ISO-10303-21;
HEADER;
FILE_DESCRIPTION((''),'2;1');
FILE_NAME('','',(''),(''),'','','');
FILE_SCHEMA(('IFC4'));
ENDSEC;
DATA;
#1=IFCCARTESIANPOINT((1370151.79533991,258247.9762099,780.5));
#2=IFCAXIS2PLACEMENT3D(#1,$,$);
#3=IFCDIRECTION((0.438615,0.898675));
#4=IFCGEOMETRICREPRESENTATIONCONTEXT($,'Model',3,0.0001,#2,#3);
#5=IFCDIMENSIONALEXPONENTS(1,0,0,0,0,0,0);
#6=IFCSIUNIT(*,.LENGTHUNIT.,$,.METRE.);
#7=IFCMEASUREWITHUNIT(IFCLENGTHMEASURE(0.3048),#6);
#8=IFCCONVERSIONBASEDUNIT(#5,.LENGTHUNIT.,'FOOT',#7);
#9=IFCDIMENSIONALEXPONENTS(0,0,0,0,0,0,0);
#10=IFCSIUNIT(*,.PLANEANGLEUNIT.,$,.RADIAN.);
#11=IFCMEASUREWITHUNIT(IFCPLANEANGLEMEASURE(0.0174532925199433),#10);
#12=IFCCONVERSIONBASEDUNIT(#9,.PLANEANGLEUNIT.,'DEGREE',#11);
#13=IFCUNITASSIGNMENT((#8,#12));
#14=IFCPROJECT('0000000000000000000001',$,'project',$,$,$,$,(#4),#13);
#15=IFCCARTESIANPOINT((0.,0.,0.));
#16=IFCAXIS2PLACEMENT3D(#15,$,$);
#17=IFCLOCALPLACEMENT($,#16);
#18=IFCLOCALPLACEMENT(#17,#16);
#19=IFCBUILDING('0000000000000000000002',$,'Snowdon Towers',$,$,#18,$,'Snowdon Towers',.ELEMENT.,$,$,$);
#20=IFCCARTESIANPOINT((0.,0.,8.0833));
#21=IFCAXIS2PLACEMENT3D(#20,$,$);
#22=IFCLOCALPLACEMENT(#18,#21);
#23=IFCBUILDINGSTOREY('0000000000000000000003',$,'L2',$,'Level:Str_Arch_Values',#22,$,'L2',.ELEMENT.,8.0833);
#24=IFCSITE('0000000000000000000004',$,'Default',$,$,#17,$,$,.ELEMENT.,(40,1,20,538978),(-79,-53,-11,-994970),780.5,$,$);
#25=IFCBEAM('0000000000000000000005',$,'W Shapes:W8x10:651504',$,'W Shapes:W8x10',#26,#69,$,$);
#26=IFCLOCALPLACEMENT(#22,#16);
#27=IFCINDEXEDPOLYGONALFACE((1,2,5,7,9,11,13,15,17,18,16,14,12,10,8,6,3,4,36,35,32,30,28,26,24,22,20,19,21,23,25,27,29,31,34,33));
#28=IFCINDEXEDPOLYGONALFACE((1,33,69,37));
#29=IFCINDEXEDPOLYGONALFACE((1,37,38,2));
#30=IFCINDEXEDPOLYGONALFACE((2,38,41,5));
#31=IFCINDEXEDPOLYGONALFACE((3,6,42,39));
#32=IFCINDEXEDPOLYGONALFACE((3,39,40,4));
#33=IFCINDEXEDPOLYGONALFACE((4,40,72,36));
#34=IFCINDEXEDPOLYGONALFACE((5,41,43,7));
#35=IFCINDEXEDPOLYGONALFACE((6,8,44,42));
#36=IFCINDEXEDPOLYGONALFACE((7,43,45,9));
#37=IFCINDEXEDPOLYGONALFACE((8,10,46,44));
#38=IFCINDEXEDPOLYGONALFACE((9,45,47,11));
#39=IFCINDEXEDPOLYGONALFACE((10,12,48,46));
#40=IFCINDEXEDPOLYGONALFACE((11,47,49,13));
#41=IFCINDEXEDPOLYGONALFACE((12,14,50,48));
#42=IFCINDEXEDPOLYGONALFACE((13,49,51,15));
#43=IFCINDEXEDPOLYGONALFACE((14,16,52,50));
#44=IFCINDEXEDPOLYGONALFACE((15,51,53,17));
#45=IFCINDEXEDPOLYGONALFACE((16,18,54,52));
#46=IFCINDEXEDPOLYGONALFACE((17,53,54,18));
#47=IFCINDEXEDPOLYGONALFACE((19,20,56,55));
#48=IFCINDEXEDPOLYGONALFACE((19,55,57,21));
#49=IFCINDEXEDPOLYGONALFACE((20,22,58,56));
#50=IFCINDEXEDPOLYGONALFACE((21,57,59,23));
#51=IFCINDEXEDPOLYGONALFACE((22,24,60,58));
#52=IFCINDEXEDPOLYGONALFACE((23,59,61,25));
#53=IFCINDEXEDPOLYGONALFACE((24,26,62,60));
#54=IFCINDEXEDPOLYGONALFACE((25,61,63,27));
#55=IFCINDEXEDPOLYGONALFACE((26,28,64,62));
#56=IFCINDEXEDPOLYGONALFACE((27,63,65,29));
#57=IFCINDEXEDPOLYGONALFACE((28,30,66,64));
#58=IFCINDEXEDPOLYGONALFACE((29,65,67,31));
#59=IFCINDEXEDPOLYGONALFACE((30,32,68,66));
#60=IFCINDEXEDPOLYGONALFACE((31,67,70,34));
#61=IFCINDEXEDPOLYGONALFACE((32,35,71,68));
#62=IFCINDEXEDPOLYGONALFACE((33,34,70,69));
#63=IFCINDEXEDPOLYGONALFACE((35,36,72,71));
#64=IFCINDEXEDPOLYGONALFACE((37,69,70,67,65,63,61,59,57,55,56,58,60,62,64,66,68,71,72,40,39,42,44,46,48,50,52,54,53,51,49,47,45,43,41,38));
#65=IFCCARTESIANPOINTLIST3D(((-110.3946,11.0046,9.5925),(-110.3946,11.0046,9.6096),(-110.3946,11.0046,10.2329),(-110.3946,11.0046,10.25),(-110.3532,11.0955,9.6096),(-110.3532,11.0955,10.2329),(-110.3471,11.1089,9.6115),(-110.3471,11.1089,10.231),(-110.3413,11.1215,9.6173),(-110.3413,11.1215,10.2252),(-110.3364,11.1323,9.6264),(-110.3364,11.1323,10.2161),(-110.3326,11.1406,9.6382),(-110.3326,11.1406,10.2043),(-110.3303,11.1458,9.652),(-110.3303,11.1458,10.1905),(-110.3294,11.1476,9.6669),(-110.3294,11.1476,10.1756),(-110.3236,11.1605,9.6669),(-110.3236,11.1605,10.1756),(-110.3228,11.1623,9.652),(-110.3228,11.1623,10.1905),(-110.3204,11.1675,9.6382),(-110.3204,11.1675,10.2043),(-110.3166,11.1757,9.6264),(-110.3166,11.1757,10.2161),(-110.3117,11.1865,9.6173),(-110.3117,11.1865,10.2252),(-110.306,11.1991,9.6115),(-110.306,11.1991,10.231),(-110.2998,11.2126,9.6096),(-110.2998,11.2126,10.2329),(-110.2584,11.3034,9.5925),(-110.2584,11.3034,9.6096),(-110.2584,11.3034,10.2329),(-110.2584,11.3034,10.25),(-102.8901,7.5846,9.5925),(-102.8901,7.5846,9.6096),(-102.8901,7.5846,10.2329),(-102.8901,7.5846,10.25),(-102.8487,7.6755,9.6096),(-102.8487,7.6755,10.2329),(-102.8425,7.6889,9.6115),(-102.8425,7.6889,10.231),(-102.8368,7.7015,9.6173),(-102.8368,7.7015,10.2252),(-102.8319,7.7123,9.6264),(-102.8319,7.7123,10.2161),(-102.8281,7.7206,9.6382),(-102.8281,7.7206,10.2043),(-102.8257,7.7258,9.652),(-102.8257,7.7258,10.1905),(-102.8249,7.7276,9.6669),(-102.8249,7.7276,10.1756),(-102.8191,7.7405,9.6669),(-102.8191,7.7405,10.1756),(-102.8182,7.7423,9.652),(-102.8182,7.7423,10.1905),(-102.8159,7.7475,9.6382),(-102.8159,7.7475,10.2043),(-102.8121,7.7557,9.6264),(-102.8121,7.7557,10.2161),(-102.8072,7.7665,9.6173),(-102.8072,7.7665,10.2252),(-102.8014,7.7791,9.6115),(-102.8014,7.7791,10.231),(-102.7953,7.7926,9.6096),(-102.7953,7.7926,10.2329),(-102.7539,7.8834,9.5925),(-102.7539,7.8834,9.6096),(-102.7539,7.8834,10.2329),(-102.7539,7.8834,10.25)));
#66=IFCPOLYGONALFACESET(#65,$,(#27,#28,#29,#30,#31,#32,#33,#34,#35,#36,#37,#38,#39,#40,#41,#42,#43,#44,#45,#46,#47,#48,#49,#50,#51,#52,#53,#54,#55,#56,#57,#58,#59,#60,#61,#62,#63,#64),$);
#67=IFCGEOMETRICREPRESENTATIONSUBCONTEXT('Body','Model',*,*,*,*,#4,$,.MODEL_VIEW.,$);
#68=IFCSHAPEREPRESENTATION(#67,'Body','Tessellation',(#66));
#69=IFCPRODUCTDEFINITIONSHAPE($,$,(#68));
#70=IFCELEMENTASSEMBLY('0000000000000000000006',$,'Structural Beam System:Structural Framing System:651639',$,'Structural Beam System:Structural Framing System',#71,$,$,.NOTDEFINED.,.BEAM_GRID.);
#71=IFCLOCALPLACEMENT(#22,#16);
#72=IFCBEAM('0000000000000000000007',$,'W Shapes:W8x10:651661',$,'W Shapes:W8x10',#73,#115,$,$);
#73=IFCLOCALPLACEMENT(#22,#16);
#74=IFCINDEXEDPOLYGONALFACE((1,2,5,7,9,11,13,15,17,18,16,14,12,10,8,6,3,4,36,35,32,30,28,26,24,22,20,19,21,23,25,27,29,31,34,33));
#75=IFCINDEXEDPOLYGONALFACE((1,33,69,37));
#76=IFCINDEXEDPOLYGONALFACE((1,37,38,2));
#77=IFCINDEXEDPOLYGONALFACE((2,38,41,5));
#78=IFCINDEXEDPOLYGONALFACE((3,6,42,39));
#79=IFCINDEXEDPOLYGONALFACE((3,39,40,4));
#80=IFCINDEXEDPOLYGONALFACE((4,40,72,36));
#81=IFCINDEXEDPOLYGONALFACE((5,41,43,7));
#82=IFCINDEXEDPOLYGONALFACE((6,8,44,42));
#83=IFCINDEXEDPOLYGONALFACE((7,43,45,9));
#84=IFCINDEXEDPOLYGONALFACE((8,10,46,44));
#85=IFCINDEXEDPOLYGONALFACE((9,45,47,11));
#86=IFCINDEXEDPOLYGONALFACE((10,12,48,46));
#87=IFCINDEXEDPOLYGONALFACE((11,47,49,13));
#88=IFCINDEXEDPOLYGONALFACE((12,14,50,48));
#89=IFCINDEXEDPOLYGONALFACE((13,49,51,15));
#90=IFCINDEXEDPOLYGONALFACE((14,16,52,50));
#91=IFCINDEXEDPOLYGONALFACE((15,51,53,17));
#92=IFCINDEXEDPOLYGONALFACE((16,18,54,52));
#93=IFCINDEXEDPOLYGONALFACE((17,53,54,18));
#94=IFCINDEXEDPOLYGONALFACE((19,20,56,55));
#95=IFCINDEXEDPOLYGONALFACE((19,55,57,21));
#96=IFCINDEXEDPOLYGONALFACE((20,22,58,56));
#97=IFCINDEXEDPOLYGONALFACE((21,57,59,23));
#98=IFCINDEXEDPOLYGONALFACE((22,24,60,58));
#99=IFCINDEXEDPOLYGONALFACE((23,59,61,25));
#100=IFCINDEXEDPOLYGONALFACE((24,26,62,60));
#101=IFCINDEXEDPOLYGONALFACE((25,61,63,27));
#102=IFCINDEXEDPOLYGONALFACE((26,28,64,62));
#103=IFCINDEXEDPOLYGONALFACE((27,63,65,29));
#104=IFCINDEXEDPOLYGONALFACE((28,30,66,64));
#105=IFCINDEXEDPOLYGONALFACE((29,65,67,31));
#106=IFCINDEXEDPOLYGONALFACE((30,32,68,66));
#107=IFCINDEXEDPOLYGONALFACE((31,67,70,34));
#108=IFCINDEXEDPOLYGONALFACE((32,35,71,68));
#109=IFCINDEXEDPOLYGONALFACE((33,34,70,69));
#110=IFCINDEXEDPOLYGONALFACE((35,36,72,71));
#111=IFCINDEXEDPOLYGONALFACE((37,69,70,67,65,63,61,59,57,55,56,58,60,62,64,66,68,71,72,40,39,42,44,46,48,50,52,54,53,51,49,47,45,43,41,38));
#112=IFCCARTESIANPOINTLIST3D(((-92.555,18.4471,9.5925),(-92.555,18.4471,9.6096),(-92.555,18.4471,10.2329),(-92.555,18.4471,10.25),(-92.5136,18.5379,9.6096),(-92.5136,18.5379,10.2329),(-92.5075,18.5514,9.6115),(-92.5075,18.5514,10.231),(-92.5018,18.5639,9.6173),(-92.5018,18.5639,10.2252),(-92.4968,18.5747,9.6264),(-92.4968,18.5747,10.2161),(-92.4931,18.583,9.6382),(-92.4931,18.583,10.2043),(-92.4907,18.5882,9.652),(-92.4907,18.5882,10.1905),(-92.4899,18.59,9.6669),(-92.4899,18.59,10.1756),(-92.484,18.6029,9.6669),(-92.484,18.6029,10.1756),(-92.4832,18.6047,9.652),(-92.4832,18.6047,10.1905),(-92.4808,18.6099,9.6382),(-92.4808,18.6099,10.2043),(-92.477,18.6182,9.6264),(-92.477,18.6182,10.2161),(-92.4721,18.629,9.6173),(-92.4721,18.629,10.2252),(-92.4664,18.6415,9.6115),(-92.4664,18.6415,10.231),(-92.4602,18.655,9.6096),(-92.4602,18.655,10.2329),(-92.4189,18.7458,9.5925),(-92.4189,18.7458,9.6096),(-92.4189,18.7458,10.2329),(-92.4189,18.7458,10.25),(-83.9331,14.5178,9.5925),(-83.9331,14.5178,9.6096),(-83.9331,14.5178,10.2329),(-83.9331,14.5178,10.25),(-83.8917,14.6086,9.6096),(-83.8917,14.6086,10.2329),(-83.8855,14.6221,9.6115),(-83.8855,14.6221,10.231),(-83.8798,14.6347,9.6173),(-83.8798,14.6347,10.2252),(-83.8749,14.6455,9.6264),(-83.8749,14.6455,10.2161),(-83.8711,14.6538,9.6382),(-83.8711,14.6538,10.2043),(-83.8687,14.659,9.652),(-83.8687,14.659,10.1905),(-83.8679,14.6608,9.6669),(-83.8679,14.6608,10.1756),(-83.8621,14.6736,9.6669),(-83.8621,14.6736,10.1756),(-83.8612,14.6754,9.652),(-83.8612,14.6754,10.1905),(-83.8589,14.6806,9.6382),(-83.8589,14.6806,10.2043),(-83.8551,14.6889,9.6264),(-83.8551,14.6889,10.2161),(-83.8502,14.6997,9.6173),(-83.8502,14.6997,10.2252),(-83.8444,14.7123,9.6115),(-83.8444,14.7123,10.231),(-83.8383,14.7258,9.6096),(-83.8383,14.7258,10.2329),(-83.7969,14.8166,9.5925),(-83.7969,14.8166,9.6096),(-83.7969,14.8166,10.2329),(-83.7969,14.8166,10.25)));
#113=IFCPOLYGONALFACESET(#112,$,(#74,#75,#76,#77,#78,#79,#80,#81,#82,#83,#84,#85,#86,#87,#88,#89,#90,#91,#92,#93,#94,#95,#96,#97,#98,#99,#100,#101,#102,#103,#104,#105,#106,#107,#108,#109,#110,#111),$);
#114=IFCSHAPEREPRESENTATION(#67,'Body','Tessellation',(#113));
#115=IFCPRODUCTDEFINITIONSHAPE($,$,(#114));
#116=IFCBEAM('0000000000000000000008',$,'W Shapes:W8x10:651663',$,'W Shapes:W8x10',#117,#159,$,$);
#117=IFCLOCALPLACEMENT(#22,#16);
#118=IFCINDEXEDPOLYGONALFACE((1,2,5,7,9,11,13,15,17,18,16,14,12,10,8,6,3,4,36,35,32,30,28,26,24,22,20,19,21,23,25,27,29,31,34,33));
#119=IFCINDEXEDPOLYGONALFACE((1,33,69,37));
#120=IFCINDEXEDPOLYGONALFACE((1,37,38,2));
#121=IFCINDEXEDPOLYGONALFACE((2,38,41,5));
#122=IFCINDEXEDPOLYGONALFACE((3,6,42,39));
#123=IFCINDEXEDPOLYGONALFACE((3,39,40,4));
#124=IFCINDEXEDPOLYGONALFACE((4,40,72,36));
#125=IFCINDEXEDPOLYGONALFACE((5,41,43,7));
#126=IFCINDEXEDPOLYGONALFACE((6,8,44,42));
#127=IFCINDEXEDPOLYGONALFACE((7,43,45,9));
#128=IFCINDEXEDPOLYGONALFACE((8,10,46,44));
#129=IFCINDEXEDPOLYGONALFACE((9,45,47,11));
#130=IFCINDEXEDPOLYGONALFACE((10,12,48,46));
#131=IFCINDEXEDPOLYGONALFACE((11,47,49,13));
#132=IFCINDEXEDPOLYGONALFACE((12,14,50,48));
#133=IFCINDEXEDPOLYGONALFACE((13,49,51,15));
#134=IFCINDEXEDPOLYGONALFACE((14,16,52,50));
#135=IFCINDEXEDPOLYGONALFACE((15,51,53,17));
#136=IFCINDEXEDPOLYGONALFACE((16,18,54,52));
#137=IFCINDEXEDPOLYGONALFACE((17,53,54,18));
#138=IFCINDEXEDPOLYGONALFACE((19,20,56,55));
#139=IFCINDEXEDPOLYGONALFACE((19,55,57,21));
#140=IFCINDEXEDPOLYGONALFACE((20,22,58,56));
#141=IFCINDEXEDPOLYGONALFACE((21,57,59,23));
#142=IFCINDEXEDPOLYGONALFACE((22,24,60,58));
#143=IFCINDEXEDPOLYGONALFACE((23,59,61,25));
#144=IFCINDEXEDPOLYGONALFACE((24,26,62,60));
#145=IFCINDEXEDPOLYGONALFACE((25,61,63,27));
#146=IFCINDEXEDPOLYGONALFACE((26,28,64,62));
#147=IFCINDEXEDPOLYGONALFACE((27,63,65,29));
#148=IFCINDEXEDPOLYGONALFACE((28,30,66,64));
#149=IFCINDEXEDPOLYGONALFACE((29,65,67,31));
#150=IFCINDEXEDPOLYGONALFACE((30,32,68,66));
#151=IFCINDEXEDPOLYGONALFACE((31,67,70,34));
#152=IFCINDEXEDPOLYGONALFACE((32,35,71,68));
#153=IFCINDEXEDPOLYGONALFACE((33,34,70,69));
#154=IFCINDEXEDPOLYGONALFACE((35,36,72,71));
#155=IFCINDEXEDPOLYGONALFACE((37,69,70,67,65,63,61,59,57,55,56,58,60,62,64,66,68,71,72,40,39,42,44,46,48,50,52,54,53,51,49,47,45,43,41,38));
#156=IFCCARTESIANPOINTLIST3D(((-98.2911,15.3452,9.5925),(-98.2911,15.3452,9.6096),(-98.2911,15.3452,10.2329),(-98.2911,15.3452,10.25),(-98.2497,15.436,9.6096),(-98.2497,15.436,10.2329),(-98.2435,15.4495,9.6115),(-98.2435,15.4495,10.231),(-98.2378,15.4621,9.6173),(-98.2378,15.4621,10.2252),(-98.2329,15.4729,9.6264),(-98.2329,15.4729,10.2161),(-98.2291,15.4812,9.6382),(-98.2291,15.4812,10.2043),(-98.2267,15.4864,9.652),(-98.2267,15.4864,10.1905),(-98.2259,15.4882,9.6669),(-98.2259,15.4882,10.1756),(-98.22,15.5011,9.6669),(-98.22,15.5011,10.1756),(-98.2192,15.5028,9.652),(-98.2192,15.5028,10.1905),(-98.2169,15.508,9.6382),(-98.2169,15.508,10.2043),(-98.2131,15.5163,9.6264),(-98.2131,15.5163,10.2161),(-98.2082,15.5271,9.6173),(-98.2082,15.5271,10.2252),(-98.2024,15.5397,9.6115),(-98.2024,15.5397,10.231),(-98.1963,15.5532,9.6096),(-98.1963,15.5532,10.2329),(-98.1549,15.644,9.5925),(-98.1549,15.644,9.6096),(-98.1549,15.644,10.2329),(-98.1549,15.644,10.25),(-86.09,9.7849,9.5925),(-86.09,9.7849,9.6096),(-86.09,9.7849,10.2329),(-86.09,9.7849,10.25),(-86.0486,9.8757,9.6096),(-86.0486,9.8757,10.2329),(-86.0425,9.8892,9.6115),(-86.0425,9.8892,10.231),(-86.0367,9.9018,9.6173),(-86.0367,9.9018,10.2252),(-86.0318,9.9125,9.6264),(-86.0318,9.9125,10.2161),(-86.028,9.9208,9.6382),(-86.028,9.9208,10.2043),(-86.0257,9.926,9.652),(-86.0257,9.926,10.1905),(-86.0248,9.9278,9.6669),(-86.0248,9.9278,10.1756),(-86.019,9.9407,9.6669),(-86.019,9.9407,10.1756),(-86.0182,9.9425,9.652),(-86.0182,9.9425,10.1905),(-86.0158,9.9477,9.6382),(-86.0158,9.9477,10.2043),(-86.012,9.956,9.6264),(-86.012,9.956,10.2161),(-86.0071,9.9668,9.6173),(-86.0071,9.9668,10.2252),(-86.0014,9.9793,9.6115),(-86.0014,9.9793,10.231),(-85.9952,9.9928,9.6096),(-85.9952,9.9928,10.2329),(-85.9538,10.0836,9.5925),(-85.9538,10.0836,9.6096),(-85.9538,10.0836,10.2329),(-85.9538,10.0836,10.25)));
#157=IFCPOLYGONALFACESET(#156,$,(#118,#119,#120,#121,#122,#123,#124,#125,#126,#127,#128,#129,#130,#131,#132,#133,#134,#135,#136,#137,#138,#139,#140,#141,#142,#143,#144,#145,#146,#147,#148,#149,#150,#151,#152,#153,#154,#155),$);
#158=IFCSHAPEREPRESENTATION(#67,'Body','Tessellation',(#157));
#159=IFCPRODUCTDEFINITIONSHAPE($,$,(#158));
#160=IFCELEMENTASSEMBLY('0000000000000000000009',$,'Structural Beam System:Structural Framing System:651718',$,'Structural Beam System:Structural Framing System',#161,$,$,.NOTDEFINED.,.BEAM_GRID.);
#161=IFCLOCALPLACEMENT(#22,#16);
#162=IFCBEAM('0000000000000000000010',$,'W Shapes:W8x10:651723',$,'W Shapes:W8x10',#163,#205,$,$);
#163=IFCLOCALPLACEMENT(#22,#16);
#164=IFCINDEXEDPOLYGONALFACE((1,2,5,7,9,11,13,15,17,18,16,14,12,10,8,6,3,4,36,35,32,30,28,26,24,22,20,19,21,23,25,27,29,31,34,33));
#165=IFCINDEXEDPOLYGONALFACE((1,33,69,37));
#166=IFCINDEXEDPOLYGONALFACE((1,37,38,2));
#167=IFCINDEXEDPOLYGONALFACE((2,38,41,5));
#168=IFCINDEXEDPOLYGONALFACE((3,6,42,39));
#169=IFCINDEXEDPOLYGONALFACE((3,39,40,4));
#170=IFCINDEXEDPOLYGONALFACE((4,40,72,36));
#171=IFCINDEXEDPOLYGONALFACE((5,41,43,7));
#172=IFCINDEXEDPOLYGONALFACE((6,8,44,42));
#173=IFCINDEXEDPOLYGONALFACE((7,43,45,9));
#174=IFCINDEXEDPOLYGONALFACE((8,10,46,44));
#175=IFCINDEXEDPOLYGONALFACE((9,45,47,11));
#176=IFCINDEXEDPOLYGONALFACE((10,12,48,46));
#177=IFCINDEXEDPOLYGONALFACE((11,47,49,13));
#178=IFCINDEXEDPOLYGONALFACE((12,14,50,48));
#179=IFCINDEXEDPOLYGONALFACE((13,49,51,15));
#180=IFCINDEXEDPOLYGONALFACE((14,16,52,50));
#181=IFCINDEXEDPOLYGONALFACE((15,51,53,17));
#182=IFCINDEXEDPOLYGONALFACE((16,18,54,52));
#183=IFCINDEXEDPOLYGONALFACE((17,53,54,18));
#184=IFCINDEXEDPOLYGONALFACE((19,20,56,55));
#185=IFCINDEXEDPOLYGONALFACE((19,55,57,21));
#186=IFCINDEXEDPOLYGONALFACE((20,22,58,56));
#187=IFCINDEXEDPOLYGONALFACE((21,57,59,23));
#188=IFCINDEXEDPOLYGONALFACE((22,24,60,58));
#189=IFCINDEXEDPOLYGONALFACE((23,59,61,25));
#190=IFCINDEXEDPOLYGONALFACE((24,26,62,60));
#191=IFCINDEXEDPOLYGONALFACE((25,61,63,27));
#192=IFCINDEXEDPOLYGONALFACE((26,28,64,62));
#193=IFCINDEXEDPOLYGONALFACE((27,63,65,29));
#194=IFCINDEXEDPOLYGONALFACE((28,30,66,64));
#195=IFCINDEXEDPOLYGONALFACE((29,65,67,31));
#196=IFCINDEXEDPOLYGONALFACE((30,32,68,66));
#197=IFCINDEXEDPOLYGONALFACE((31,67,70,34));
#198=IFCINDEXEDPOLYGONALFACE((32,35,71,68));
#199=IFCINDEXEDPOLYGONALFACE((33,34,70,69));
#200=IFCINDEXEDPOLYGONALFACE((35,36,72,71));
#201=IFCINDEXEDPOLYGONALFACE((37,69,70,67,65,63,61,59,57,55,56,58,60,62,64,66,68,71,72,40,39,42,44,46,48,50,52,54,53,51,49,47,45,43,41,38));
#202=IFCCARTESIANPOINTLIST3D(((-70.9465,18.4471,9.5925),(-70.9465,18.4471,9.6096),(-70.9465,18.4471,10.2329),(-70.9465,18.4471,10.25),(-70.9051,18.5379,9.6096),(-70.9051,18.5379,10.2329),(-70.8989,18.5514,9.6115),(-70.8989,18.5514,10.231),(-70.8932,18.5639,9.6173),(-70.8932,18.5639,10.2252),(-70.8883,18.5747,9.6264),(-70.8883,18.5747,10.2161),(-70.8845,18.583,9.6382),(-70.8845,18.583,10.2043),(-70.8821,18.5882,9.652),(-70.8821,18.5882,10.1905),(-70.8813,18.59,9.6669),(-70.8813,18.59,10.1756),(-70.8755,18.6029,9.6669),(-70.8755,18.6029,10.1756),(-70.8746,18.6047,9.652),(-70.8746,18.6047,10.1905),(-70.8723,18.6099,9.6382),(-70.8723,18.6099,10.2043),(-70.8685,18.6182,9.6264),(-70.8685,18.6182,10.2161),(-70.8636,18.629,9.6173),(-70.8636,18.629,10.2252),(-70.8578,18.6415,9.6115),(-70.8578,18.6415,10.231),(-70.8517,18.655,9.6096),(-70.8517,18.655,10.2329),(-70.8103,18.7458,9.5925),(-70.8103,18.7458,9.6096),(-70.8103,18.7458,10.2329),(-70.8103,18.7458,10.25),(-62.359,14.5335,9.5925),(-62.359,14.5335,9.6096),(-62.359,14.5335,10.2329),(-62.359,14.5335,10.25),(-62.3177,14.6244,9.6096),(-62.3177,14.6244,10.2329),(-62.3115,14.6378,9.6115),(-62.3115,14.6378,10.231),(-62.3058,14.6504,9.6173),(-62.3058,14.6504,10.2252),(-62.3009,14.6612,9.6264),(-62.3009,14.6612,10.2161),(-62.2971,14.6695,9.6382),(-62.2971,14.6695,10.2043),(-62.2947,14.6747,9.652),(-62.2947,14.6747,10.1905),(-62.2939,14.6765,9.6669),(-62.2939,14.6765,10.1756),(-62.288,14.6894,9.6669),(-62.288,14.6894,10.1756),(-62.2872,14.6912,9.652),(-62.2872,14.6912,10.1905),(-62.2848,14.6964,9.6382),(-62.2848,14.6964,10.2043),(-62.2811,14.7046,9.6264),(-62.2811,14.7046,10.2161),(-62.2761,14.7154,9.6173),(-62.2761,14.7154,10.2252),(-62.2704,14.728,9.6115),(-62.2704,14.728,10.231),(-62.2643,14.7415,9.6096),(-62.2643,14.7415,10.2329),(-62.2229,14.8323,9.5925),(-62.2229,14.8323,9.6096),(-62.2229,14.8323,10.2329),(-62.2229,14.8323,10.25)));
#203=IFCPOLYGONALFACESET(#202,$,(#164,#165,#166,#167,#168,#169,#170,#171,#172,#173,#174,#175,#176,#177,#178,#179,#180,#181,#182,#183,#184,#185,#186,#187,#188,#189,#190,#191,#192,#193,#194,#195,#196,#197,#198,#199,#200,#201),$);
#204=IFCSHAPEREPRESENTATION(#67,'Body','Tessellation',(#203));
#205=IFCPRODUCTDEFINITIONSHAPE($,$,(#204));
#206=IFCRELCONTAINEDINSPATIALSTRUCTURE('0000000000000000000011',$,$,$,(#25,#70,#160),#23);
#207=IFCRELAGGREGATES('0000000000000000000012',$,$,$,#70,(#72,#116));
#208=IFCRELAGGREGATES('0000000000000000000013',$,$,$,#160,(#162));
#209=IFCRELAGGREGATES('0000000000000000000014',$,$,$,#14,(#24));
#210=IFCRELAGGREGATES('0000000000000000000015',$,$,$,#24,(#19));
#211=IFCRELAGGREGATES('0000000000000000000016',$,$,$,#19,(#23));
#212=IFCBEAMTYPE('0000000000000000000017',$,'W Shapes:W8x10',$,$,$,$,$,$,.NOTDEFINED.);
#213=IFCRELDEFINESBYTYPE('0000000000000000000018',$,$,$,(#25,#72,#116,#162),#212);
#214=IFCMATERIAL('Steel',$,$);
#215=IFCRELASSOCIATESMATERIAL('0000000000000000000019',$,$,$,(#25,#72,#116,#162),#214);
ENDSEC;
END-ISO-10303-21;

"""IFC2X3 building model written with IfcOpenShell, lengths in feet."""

from ifc_helpers import new_model, entity, si_unit, converted_unit, direction, frame, frame_2d, origin, place, context, subcontext, project, spatial, i_section, extrude, material, type_object, element, aggregate, save


model = new_model("IFC2X3")

# Units and contexts
model_context = context("Model", 3, precision=0.0001, world=frame((1370151.79533991, 258247.9762099, 780.5)), true_north=direction((0.438615, 0.898675)))
body_context = subcontext(model_context, "Body", "Model", "MODEL_VIEW")
ifc_project = project(units=[converted_unit("LENGTHUNIT", "FOOT", entity("IfcLengthMeasure", 0.3048), si_unit("LENGTHUNIT", "METRE"), dimensions=[1, 0, 0, 0, 0, 0, 0]), converted_unit("PLANEANGLEUNIT", "DEGREE", entity("IfcPlaneAngleMeasure", 0.0174532925199433), si_unit("PLANEANGLEUNIT", "RADIAN"), dimensions=[0, 0, 0, 0, 0, 0, 0])], contexts=[model_context])

# Site, building, storey
site_placement = place(None, origin())
site = spatial("IfcSite", under=ifc_project, at=site_placement, Name="Default", CompositionType="ELEMENT", RefLatitude=(40, 1, 20, 538978), RefLongitude=(-79, -53, -11, -994970), RefElevation=780.5)
building_placement = place(site_placement, origin())
building = spatial("IfcBuilding", under=site, at=building_placement, Name="Snowdon Towers", LongName="Snowdon Towers", CompositionType="ELEMENT")
storey_placement = place(building_placement, frame((0.0, 0.0, 8.0833)))
storey = spatial("IfcBuildingStorey", under=building, at=storey_placement, Name="L2", ObjectType="Level:Str_Arch_Values", LongName="L2", CompositionType="ELEMENT", Elevation=8.0833)

# Beam
ifc_material = material(Name="Steel")
beam_type_1 = type_object("IfcBeamType", Name="W Shapes:W8x10", PredefinedType="NOTDEFINED")
beam_1_placement = place(storey_placement, frame((-110.7083, 11.328, 10.25), z_axis=(0.0, 0.0, 1.0), x_axis=(0.909961, -0.414693, 0.0)))
element("IfcBeam", 1, at=beam_1_placement, inside=storey, type_object=beam_type_1, material=ifc_material, Name="W Shapes:W8x10:651504", ObjectType="W Shapes:W8x10", context=body_context, shape_type="SweptSolid", body=[
    extrude(i_section(OverallWidth=0.3283, OverallDepth=0.6575, WebThickness=0.0142, FlangeThickness=0.0171, FilletRadius=0.0573, at=frame_2d((0.0, 0.0), x_axis=(0.0, 1.0))), frame((0.4196, 0.0, -0.3288), z_axis=(1.0, 0.0, 0.0), x_axis=(0.0, 0.0, -1.0)), (0.0, 0.0, 1.0), 8.2471),
])

# Element assemblies, beams
assembly_1_placement = place(storey_placement, origin())
assembly_1 = element("IfcElementAssembly", 2, at=assembly_1_placement, inside=storey, Name="Structural Beam System:Structural Framing System:651639", ObjectType="Structural Beam System:Structural Framing System", AssemblyPlace="NOTDEFINED", PredefinedType="BEAM_GRID")
beam_2_placement = place(assembly_1_placement, frame((-93.8296, 19.2083, 10.25), z_axis=(0.0, 0.0, 1.0), x_axis=(0.909961, -0.414693, 0.0)))
beam_2 = element("IfcBeam", 3, at=beam_2_placement, type_object=beam_type_1, material=ifc_material, Name="W Shapes:W8x10:651661", ObjectType="W Shapes:W8x10", context=body_context, shape_type="SweptSolid", body=[
    extrude(i_section(OverallWidth=0.3283, OverallDepth=0.6575, WebThickness=0.0142, FlangeThickness=0.0171, FilletRadius=0.0573, at=frame_2d((0.0, 0.0), x_axis=(0.0, 1.0))), frame((1.4755, 0.0, -0.3288), z_axis=(1.0, 0.0, 0.0), x_axis=(0.0, 0.0, -1.0)), (0.0, 0.0, 1.0), 9.4751),
])
beam_3_placement = place(assembly_1_placement, frame((-98.6438, 15.6864, 10.25), z_axis=(0.0, 0.0, 1.0), x_axis=(0.909961, -0.414693, 0.0)))
beam_3 = element("IfcBeam", 4, at=beam_3_placement, type_object=beam_type_1, material=ifc_material, Name="W Shapes:W8x10:651663", ObjectType="W Shapes:W8x10", context=body_context, shape_type="SweptSolid", body=[
    extrude(i_section(OverallWidth=0.3283, OverallDepth=0.6575, WebThickness=0.0142, FlangeThickness=0.0171, FilletRadius=0.0573, at=frame_2d((0.0, 0.0), x_axis=(0.0, 1.0))), frame((0.4625, 0.0, -0.3288), z_axis=(1.0, 0.0, 0.0), x_axis=(0.0, 0.0, -1.0)), (0.0, 0.0, 1.0), 13.4083),
])
aggregate(assembly_1, [beam_2, beam_3])
assembly_2_placement = place(storey_placement, origin())
assembly_2 = element("IfcElementAssembly", 5, at=assembly_2_placement, inside=storey, Name="Structural Beam System:Structural Framing System:651718", ObjectType="Structural Beam System:Structural Framing System", AssemblyPlace="NOTDEFINED", PredefinedType="BEAM_GRID")
beam_4_placement = place(assembly_2_placement, frame((-72.2211, 19.2083, 10.25), z_axis=(0.0, 0.0, 1.0), x_axis=(0.909961, -0.414693, 0.0)))
beam_4 = element("IfcBeam", 6, at=beam_4_placement, type_object=beam_type_1, material=ifc_material, Name="W Shapes:W8x10:651723", ObjectType="W Shapes:W8x10", context=body_context, shape_type="SweptSolid", body=[
    extrude(i_section(OverallWidth=0.3283, OverallDepth=0.6575, WebThickness=0.0142, FlangeThickness=0.0171, FilletRadius=0.0573, at=frame_2d((0.0, 0.0), x_axis=(0.0, 1.0))), frame((1.4755, 0.0, -0.3288), z_axis=(1.0, 0.0, 0.0), x_axis=(0.0, 0.0, -1.0)), (0.0, 0.0, 1.0), 9.4371),
])
aggregate(assembly_2, [beam_4])

save(model, "model.ifc")
